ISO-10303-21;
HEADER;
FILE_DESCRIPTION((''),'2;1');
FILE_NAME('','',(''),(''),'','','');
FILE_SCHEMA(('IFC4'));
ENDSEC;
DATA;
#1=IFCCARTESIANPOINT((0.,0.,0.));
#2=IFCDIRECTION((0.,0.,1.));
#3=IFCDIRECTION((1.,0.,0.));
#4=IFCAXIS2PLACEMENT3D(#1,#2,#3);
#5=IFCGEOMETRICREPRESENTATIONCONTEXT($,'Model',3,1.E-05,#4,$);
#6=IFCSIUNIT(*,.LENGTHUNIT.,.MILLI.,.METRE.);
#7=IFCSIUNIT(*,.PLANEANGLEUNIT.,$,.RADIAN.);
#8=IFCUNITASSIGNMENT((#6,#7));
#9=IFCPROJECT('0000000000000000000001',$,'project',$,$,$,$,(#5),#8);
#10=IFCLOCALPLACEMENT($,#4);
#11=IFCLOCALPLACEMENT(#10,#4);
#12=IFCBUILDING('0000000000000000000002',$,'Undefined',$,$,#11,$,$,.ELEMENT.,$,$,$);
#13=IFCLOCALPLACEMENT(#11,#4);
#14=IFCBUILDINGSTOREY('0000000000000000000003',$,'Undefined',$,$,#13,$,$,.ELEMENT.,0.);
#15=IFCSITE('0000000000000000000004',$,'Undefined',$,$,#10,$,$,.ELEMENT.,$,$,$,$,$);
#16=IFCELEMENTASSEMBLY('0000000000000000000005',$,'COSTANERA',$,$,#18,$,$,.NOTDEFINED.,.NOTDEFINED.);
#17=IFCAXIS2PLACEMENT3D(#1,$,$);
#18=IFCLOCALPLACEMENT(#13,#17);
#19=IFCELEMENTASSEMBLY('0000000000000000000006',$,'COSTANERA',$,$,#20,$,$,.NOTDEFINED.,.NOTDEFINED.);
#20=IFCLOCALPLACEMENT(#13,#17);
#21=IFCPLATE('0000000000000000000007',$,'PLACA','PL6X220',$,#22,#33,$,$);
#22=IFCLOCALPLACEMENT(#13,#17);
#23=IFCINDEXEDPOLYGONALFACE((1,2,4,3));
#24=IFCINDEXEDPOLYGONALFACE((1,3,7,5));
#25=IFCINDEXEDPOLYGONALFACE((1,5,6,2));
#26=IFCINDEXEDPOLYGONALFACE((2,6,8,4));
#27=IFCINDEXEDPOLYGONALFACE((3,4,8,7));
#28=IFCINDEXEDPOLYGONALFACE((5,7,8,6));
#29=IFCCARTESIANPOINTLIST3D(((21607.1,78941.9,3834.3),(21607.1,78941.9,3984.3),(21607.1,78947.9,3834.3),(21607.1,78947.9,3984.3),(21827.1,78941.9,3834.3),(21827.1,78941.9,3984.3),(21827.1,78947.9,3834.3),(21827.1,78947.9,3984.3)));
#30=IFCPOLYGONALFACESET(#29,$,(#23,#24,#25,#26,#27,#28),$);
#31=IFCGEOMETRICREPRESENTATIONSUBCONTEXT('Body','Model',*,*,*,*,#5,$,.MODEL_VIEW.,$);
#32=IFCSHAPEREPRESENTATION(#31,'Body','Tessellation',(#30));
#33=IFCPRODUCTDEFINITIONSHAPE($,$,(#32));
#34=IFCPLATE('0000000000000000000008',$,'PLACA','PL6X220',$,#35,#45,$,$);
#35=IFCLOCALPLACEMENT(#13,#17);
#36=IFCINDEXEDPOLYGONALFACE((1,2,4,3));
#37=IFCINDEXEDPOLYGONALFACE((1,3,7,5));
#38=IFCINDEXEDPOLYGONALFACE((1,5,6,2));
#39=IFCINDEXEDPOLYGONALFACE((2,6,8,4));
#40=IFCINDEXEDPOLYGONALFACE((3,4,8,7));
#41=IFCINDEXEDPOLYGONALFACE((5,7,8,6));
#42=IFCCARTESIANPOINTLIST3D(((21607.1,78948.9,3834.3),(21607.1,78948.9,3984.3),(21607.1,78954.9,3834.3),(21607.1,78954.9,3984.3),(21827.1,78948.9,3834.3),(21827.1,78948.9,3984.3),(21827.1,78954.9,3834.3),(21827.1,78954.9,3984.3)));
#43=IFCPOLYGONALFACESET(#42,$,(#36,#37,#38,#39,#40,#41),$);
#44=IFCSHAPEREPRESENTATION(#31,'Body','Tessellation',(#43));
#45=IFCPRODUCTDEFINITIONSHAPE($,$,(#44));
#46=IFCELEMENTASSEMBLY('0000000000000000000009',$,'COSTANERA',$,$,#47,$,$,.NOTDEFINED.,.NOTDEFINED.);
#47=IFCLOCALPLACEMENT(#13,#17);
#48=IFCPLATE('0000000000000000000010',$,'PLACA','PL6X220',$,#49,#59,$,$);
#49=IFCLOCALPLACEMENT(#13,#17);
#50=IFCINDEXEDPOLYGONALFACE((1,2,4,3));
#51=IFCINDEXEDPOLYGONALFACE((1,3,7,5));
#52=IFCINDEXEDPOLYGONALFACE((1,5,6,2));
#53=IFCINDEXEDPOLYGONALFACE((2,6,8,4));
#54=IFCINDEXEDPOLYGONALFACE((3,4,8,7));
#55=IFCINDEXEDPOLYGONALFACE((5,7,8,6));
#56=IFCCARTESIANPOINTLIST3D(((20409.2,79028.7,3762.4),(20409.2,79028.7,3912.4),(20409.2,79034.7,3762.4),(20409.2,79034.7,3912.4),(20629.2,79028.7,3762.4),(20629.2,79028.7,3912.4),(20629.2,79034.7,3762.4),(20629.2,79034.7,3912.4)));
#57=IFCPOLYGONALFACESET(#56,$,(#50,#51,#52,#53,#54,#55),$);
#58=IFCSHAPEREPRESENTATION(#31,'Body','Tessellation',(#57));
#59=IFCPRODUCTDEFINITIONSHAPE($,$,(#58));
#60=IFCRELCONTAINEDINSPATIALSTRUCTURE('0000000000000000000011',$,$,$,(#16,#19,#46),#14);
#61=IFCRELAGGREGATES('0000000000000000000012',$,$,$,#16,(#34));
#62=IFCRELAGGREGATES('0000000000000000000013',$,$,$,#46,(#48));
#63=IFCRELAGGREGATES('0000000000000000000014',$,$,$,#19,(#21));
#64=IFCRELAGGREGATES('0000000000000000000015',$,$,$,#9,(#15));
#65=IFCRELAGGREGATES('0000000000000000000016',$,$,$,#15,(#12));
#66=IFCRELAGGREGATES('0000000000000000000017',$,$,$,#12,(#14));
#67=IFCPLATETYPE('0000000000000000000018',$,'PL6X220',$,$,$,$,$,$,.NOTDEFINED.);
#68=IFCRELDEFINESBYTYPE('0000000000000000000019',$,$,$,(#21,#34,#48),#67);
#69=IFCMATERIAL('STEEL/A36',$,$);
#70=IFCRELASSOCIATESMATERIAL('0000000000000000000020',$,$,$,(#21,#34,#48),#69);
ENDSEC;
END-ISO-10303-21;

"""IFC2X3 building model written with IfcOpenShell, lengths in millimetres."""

from ifc_helpers import new_model, si_unit, frame, origin_with_axes, place, context, subcontext, project, spatial, polyline, outline, extrude, material, type_object, element, aggregate, save


model = new_model("IFC2X3")

# Units and contexts
model_context = context("Model", 3, precision=1e-05, world=origin_with_axes())
body_context = subcontext(model_context, "Body", "Model", "MODEL_VIEW")
ifc_project = project(units=[si_unit("LENGTHUNIT", "METRE", prefix="MILLI"), si_unit("PLANEANGLEUNIT", "RADIAN")], contexts=[model_context])

# Site, building, storey
site_placement = place(None, origin_with_axes())
site = spatial("IfcSite", under=ifc_project, at=site_placement, Name="Undefined", CompositionType="ELEMENT")
building_placement = place(site_placement, origin_with_axes())
building = spatial("IfcBuilding", under=site, at=building_placement, Name="Undefined", CompositionType="ELEMENT")
storey_placement = place(building_placement, origin_with_axes())
storey = spatial("IfcBuildingStorey", under=building, at=storey_placement, Name="Undefined", CompositionType="ELEMENT", Elevation=0.0)

# Element assembly
ifc_material_1 = material(Name="STEEL/A36")
assembly_1_placement = place(storey_placement, origin_with_axes())
assembly_1 = element("IfcElementAssembly", 1, at=assembly_1_placement, inside=storey, Name="COSTANERA", AssemblyPlace="NOTDEFINED", PredefinedType="NOTDEFINED")

# Shared definitions
plate_type_1 = type_object("IfcPlateType", Name="PL6X220", PredefinedType="NOTDEFINED")

# Element assembly, plate
assembly_2_placement = place(storey_placement, origin_with_axes())
assembly_2 = element("IfcElementAssembly", 2, at=assembly_2_placement, inside=storey, Name="COSTANERA", AssemblyPlace="NOTDEFINED", PredefinedType="NOTDEFINED")
plate_1_placement = place(assembly_2_placement, frame((21717.1, 78944.9, 3834.3), z_axis=(0.0, -1.0, 0.0), x_axis=(0.0, 0.0, 1.0)))
plate_1 = element("IfcPlate", 3, at=plate_1_placement, type_object=plate_type_1, material=ifc_material_1, Name="PLACA", Description="PL6X220", context=body_context, shape_type="SweptSolid", body=[
    extrude(outline(polyline([(0.0, -110.0), (0.0, 110.0), (150.0, 110.0), (150.0, -110.0), (0.0, -110.0)])), frame((0.0, 0.0, -3.0), z_axis=(0.0, 0.0, 1.0), x_axis=(1.0, 0.0, 0.0)), (0.0, 0.0, 1.0), 6.0),
])

# Plate
plate_2_placement = place(assembly_1_placement, frame((21717.1, 78951.9, 3834.3), z_axis=(0.0, -1.0, 0.0), x_axis=(0.0, 0.0, 1.0)))
plate_2 = element("IfcPlate", 4, at=plate_2_placement, type_object=plate_type_1, material=ifc_material_1, Name="PLACA", Description="PL6X220", context=body_context, shape_type="SweptSolid", body=[
    extrude(outline(polyline([(0.0, -110.0), (0.0, 110.0), (150.0, 110.0), (150.0, -110.0), (0.0, -110.0)])), frame((0.0, 0.0, -3.0), z_axis=(0.0, 0.0, 1.0), x_axis=(1.0, 0.0, 0.0)), (0.0, 0.0, 1.0), 6.0),
])
aggregate(assembly_1, [plate_2])

# Element assembly, plate
assembly_3_placement = place(storey_placement, origin_with_axes())
assembly_3 = element("IfcElementAssembly", 5, at=assembly_3_placement, inside=storey, Name="COSTANERA", AssemblyPlace="NOTDEFINED", PredefinedType="NOTDEFINED")
plate_3_placement = place(assembly_3_placement, frame((20519.2, 79031.7, 3762.4), z_axis=(0.0, 1.0, 0.0), x_axis=(0.0, 0.0, 1.0)))
plate_3 = element("IfcPlate", 6, at=plate_3_placement, type_object=plate_type_1, material=ifc_material_1, Name="PLACA", Description="PL6X220", context=body_context, shape_type="SweptSolid", body=[
    extrude(outline(polyline([(0.0, -110.0), (0.0, 110.0), (150.0, 110.0), (150.0, -110.0), (0.0, -110.0)])), frame((0.0, 0.0, -3.0), z_axis=(0.0, 0.0, 1.0), x_axis=(1.0, 0.0, 0.0)), (0.0, 0.0, 1.0), 6.0),
])
aggregate(assembly_3, [plate_3])

aggregate(assembly_2, [plate_1])

save(model, "model.ifc")
